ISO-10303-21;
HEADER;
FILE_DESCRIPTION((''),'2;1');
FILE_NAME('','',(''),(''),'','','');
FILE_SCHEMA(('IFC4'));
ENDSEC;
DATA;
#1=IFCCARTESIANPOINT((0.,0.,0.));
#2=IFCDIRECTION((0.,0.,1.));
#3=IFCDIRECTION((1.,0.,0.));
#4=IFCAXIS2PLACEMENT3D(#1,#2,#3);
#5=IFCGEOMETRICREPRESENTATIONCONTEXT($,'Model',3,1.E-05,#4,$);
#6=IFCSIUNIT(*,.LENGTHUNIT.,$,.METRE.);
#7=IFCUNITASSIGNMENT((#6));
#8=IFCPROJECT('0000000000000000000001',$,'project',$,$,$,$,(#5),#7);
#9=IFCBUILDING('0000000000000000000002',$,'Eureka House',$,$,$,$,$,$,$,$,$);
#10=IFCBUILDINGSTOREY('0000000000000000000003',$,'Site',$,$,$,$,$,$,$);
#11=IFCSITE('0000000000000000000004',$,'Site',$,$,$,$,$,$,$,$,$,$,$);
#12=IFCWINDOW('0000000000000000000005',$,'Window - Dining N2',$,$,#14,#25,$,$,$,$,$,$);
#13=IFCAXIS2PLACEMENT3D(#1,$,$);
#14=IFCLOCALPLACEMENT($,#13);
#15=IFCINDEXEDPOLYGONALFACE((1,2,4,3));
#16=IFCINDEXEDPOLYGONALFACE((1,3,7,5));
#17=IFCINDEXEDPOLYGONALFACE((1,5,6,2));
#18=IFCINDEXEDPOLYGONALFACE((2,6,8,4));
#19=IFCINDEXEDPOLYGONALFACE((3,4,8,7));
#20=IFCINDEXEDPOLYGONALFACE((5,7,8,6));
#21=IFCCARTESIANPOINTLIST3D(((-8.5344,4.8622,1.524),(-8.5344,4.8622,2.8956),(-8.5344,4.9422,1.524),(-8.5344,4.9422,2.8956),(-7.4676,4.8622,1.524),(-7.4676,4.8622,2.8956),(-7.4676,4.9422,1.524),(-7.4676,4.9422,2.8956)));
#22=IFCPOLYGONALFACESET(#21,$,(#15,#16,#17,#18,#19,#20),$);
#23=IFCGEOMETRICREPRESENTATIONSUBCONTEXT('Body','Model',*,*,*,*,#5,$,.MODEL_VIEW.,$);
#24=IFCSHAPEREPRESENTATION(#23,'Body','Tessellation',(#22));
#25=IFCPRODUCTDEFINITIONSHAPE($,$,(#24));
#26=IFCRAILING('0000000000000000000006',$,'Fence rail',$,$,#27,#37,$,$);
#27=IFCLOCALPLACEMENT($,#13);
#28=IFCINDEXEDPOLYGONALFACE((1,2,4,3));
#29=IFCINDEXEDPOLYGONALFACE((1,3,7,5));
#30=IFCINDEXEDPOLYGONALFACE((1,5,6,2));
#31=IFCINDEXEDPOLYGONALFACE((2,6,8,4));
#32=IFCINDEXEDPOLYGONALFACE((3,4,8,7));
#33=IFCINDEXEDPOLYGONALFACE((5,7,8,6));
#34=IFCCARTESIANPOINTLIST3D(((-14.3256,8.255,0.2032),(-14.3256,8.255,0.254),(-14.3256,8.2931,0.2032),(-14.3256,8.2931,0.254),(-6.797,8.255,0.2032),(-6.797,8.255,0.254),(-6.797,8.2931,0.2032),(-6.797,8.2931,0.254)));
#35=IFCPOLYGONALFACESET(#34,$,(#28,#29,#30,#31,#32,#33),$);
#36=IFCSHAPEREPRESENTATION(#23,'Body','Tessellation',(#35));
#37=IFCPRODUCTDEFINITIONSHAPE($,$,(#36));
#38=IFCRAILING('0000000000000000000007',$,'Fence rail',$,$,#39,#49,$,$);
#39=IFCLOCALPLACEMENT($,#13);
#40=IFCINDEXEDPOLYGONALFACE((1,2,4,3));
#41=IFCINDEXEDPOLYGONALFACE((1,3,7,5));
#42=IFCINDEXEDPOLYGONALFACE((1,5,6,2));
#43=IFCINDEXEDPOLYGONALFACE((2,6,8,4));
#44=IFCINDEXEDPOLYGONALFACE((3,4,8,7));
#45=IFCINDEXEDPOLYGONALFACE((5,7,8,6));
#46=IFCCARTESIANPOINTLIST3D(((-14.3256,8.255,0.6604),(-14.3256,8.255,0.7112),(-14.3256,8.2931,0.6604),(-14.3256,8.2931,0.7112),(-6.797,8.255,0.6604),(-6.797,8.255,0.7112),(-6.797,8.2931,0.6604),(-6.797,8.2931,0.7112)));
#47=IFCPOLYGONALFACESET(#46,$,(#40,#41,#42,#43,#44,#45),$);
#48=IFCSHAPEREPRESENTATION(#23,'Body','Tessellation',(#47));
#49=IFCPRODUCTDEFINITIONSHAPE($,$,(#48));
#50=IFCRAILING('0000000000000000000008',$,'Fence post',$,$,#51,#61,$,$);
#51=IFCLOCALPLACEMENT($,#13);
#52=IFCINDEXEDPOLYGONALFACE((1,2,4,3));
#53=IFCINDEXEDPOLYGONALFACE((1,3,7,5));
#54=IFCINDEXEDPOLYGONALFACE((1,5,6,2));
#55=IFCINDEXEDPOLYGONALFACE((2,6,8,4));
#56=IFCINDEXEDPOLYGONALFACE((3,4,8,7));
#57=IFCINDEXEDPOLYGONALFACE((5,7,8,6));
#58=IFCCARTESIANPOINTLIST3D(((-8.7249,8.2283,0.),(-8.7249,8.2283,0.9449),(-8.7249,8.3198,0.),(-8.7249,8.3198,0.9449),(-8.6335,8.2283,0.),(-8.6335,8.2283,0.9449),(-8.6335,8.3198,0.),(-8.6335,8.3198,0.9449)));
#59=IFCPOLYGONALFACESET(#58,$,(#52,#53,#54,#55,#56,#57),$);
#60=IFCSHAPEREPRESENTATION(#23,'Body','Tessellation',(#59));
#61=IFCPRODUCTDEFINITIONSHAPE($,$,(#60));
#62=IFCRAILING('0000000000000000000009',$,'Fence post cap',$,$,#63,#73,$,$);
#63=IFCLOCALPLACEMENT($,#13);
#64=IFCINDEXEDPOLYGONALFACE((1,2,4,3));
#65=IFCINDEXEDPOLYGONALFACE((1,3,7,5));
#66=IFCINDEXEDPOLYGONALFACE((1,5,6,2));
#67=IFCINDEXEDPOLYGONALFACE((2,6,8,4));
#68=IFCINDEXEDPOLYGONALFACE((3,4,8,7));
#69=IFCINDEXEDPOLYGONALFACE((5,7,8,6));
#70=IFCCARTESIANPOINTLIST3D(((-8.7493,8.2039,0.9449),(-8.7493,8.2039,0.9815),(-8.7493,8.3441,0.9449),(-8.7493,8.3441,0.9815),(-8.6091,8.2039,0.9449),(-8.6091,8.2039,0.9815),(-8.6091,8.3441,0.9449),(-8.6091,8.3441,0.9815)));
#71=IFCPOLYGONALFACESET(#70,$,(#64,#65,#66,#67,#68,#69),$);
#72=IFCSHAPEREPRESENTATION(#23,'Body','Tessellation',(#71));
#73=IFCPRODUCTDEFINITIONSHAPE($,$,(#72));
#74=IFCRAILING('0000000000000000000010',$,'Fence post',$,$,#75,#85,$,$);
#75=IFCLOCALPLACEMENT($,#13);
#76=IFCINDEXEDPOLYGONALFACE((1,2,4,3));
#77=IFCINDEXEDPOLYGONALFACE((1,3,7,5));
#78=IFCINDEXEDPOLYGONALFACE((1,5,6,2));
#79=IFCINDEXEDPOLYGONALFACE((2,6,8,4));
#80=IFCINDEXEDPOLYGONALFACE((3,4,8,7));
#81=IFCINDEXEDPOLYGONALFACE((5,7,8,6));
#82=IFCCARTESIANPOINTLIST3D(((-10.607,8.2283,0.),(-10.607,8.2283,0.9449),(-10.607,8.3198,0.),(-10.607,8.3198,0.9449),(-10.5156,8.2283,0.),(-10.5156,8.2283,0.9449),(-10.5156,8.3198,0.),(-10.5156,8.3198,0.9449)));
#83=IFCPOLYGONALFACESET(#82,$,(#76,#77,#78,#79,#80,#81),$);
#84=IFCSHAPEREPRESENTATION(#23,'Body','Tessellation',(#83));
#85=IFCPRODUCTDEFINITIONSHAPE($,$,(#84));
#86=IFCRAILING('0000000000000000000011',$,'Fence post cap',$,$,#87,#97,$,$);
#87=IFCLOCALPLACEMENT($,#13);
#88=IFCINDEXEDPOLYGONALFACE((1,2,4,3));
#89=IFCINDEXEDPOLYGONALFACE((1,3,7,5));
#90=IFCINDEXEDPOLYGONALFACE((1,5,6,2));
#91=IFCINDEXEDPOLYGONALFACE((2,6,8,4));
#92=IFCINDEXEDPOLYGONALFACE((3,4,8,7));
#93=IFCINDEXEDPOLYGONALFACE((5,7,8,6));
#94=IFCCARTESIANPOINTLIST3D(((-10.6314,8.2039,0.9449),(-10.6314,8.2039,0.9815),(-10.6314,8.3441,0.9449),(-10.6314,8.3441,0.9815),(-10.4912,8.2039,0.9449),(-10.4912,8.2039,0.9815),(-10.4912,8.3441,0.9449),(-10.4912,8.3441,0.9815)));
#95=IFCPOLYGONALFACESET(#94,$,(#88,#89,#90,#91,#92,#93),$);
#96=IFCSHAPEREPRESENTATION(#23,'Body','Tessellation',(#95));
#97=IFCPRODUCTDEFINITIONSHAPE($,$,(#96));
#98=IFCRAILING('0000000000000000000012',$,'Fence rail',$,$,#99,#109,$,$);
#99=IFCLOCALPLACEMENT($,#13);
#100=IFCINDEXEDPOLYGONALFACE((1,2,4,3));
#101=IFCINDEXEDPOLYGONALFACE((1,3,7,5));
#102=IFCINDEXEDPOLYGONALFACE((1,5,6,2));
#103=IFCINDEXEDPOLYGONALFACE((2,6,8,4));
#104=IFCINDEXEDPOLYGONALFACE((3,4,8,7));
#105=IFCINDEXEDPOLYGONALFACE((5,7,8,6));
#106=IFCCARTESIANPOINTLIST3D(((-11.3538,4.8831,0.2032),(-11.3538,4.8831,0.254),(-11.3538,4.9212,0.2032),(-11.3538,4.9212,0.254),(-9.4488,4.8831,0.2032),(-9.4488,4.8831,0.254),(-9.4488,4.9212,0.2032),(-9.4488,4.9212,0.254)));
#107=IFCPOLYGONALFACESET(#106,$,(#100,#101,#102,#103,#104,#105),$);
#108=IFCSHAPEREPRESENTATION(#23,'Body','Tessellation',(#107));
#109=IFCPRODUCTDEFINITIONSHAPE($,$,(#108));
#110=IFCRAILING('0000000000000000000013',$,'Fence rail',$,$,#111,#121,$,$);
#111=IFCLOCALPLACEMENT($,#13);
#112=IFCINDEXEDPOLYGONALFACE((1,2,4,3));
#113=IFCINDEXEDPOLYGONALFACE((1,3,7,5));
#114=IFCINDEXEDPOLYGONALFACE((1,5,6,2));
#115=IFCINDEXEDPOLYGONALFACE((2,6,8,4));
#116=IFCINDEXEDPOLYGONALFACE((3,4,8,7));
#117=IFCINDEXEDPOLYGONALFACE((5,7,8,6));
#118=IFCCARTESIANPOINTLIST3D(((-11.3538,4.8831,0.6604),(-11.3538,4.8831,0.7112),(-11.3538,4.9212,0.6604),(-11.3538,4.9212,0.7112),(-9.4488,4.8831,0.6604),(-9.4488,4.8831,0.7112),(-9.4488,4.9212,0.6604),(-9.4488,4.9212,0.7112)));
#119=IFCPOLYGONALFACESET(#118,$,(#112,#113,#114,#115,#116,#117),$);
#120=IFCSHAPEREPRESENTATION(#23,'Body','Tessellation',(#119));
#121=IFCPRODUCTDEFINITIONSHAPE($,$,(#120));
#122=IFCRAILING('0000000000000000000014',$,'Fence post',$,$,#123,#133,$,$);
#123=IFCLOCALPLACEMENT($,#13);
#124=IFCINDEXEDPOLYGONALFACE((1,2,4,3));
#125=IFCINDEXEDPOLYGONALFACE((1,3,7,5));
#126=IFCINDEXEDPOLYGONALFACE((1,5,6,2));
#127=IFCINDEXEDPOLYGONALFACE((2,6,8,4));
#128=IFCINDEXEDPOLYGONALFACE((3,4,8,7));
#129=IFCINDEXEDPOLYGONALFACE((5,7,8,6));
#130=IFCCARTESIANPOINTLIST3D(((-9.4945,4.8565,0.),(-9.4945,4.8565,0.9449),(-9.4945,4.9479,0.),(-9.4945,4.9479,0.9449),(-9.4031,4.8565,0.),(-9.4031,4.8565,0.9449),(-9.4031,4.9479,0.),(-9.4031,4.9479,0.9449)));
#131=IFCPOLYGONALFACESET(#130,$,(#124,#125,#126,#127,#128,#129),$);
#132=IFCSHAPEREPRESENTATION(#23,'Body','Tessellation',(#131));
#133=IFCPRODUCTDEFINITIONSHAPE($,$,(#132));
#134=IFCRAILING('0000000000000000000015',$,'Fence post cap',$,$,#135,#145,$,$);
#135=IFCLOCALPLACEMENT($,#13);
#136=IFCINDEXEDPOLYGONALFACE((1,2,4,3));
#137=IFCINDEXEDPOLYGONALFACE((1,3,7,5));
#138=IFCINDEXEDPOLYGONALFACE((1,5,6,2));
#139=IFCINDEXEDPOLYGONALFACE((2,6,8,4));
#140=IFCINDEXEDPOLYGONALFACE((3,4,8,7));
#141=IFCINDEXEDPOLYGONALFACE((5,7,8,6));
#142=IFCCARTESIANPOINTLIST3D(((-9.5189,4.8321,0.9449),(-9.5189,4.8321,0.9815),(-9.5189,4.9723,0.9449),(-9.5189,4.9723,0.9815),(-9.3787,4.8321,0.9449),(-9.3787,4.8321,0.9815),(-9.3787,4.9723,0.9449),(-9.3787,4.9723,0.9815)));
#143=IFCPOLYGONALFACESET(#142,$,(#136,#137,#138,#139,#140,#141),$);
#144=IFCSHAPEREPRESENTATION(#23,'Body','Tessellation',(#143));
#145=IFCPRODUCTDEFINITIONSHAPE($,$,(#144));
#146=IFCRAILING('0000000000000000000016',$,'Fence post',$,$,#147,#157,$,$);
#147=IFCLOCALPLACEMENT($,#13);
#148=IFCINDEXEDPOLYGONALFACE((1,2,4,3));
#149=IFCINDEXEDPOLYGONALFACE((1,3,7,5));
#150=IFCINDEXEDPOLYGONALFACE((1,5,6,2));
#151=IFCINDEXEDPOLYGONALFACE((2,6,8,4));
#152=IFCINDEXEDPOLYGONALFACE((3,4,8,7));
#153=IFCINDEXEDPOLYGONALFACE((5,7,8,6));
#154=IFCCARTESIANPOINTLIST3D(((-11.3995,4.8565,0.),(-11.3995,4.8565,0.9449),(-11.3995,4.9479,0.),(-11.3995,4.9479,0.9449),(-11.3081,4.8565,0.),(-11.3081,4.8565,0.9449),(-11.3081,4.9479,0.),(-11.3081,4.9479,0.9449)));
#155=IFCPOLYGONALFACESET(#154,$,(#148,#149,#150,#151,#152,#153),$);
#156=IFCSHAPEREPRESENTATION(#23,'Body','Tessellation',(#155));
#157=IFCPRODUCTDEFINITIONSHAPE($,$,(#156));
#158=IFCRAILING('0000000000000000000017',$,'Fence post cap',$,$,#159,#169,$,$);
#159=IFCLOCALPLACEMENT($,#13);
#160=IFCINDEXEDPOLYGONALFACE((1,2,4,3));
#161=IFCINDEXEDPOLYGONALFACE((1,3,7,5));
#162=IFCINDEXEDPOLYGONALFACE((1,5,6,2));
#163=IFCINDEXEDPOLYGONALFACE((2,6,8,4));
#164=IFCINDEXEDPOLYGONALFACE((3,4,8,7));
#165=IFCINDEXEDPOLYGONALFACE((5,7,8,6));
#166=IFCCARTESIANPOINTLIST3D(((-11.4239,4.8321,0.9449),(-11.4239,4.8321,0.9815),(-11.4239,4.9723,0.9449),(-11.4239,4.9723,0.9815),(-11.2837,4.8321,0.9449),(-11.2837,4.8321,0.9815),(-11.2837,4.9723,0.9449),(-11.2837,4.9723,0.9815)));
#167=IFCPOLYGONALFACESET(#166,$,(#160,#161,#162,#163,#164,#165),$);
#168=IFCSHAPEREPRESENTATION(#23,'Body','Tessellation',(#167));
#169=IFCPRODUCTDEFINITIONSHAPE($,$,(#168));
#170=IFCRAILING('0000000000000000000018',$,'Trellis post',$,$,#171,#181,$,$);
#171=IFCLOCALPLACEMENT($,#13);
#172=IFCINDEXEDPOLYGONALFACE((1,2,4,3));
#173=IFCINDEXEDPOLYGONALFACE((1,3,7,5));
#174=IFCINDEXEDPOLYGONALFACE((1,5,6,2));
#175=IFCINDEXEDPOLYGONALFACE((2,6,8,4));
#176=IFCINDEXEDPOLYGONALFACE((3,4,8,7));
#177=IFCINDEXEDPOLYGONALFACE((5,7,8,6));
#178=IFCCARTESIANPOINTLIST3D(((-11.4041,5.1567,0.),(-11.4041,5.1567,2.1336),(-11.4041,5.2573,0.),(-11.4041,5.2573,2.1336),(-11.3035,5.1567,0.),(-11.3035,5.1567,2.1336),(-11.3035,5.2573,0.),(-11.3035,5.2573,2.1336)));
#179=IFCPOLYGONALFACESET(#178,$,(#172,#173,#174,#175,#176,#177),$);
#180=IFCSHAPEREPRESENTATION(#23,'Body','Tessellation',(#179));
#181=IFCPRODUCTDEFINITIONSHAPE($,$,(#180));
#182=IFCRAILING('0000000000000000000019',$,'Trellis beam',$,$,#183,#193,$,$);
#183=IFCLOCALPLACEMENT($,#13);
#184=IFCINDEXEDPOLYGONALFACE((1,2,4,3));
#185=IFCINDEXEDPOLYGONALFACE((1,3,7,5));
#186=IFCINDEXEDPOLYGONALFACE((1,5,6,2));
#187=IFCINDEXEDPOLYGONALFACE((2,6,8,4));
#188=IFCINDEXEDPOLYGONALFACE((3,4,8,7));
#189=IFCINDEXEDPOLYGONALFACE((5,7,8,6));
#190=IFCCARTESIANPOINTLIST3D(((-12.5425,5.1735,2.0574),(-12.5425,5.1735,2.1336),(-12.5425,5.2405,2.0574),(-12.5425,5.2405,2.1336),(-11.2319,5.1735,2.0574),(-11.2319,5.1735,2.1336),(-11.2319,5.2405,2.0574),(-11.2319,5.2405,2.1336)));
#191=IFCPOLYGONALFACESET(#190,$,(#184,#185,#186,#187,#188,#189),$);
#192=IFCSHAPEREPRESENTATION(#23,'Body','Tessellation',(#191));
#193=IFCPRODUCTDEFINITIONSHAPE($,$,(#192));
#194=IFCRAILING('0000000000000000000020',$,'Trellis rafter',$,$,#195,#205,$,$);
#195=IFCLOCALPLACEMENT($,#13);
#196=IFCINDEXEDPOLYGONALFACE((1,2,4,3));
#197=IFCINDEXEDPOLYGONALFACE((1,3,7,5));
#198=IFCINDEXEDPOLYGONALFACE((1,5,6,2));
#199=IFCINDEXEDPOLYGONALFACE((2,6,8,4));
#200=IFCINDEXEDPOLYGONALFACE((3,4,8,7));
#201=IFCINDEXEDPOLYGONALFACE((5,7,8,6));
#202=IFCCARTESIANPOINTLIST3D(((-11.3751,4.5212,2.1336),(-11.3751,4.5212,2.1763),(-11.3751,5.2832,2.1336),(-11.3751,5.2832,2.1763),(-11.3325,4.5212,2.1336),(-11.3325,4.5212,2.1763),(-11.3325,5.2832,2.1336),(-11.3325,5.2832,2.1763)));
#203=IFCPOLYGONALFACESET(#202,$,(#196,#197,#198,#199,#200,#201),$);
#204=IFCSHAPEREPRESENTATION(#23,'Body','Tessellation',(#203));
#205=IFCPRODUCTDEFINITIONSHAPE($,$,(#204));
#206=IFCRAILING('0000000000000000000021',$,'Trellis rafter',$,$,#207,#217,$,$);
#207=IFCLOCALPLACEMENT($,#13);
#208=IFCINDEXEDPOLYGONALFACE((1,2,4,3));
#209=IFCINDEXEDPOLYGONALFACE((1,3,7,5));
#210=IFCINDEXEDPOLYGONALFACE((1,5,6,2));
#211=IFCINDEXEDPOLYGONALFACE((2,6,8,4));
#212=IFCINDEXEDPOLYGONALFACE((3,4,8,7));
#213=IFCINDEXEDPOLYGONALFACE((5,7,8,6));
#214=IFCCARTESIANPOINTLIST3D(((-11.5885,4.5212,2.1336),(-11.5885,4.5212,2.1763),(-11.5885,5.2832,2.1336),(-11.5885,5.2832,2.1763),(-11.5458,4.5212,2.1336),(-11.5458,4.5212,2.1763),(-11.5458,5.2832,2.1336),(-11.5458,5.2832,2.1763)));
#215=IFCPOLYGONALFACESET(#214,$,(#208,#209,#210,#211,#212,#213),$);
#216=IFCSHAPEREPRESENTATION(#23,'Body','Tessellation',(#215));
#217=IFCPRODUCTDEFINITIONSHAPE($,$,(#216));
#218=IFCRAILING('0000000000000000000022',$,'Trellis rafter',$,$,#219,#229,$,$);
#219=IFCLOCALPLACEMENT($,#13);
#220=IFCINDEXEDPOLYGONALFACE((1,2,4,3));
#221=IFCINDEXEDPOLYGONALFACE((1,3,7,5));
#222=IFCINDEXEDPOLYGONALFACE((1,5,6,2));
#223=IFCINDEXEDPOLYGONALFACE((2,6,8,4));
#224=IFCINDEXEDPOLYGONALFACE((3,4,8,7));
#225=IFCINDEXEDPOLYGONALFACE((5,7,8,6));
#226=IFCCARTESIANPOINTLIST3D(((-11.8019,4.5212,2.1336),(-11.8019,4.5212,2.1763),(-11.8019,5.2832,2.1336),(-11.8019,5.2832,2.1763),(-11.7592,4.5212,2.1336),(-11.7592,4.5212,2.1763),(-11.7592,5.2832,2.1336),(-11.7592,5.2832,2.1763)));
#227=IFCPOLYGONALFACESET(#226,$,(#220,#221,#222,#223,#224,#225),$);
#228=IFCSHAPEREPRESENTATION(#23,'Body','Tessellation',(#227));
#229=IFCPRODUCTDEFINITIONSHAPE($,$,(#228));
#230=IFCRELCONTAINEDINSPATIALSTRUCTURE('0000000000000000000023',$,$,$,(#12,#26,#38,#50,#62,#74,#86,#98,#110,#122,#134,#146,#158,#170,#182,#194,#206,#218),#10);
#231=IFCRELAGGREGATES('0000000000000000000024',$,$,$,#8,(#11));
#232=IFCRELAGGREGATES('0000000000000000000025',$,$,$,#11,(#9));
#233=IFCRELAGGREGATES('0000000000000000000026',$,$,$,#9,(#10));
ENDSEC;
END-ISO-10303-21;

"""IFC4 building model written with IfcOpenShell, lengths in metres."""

from ifc_helpers import new_model, si_unit, frame, origin, origin_with_axes, origin_2d, place, context, subcontext, project, spatial, rectangle, extrude, element, save


model = new_model("IFC4")

# Units and contexts
model_context = context("Model", 3, precision=1e-05, world=origin_with_axes())
body_context = subcontext(model_context, "Body", "Model", "MODEL_VIEW")
ifc_project = project(units=[si_unit("LENGTHUNIT", "METRE")], contexts=[model_context])

# Site, building, storey
site = spatial("IfcSite", under=ifc_project, Name="Site")
building = spatial("IfcBuilding", under=site, Name="Eureka House")
storey = spatial("IfcBuildingStorey", under=building, Name="Site")

# Window
window_placement = place(None, frame((-8.001, 4.9022, 1.524), z_axis=(0.0, 0.0, 1.0), x_axis=(1.0, 0.0, 0.0)))
element("IfcWindow", 1, at=window_placement, inside=storey, Name="Window - Dining N2", context=body_context, shape_type="SweptSolid", body=[
    extrude(rectangle(XDim=1.0668, YDim=0.08, at=origin_2d()), origin(), (0.0, 0.0, 1.0), 1.3716),
])

# Railings
for number, where, z_axis, x_axis, name in (
    (2, (-10.5613, 8.274, 0.2032), (0.0, 0.0, 1.0), (1.0, 0.0, 0.0), "Fence rail"),
    (3, (-10.5613, 8.274, 0.6604), (0.0, 0.0, 1.0), (1.0, 0.0, 0.0), "Fence rail"),
):
    element("IfcRailing", number, at=place(None, frame(where, z_axis=z_axis, x_axis=x_axis)), inside=storey, Name=name, context=body_context, shape_type="SweptSolid", body=[
        extrude(rectangle(XDim=7.5286, YDim=0.0381, at=origin_2d()), origin(), (0.0, 0.0, 1.0), 0.0508),
    ])
railing_1_placement = place(None, frame((-8.6792, 8.274, 0.0), z_axis=(0.0, 0.0, 1.0), x_axis=(1.0, 0.0, 0.0)))
element("IfcRailing", 4, at=railing_1_placement, inside=storey, Name="Fence post", context=body_context, shape_type="SweptSolid", body=[
    extrude(rectangle(XDim=0.0914, YDim=0.0914, at=origin_2d()), origin(), (0.0, 0.0, 1.0), 0.9449),
])
railing_2_placement = place(None, frame((-8.6792, 8.274, 0.9449), z_axis=(0.0, 0.0, 1.0), x_axis=(1.0, 0.0, 0.0)))
element("IfcRailing", 5, at=railing_2_placement, inside=storey, Name="Fence post cap", context=body_context, shape_type="SweptSolid", body=[
    extrude(rectangle(XDim=0.1402, YDim=0.1402, at=origin_2d()), origin(), (0.0, 0.0, 1.0), 0.0366),
])
railing_3_placement = place(None, frame((-10.5613, 8.274, 0.0), z_axis=(0.0, 0.0, 1.0), x_axis=(1.0, 0.0, 0.0)))
element("IfcRailing", 6, at=railing_3_placement, inside=storey, Name="Fence post", context=body_context, shape_type="SweptSolid", body=[
    extrude(rectangle(XDim=0.0914, YDim=0.0914, at=origin_2d()), origin(), (0.0, 0.0, 1.0), 0.9449),
])
railing_4_placement = place(None, frame((-10.5613, 8.274, 0.9449), z_axis=(0.0, 0.0, 1.0), x_axis=(1.0, 0.0, 0.0)))
element("IfcRailing", 7, at=railing_4_placement, inside=storey, Name="Fence post cap", context=body_context, shape_type="SweptSolid", body=[
    extrude(rectangle(XDim=0.1402, YDim=0.1402, at=origin_2d()), origin(), (0.0, 0.0, 1.0), 0.0366),
])
for number, where, z_axis, x_axis, name in (
    (8, (-10.4013, 4.9022, 0.2032), (0.0, 0.0, 1.0), (1.0, 0.0, 0.0), "Fence rail"),
    (9, (-10.4013, 4.9022, 0.6604), (0.0, 0.0, 1.0), (1.0, 0.0, 0.0), "Fence rail"),
):
    element("IfcRailing", number, at=place(None, frame(where, z_axis=z_axis, x_axis=x_axis)), inside=storey, Name=name, context=body_context, shape_type="SweptSolid", body=[
        extrude(rectangle(XDim=1.905, YDim=0.0381, at=origin_2d()), origin(), (0.0, 0.0, 1.0), 0.0508),
    ])
railing_5_placement = place(None, frame((-9.4488, 4.9022, 0.0), z_axis=(0.0, 0.0, 1.0), x_axis=(1.0, 0.0, 0.0)))
element("IfcRailing", 10, at=railing_5_placement, inside=storey, Name="Fence post", context=body_context, shape_type="SweptSolid", body=[
    extrude(rectangle(XDim=0.0914, YDim=0.0914, at=origin_2d()), origin(), (0.0, 0.0, 1.0), 0.9449),
])
railing_6_placement = place(None, frame((-9.4488, 4.9022, 0.9449), z_axis=(0.0, 0.0, 1.0), x_axis=(1.0, 0.0, 0.0)))
element("IfcRailing", 11, at=railing_6_placement, inside=storey, Name="Fence post cap", context=body_context, shape_type="SweptSolid", body=[
    extrude(rectangle(XDim=0.1402, YDim=0.1402, at=origin_2d()), origin(), (0.0, 0.0, 1.0), 0.0366),
])
railing_7_placement = place(None, frame((-11.3538, 4.9022, 0.0), z_axis=(0.0, 0.0, 1.0), x_axis=(1.0, 0.0, 0.0)))
element("IfcRailing", 12, at=railing_7_placement, inside=storey, Name="Fence post", context=body_context, shape_type="SweptSolid", body=[
    extrude(rectangle(XDim=0.0914, YDim=0.0914, at=origin_2d()), origin(), (0.0, 0.0, 1.0), 0.9449),
])
railing_8_placement = place(None, frame((-11.3538, 4.9022, 0.9449), z_axis=(0.0, 0.0, 1.0), x_axis=(1.0, 0.0, 0.0)))
element("IfcRailing", 13, at=railing_8_placement, inside=storey, Name="Fence post cap", context=body_context, shape_type="SweptSolid", body=[
    extrude(rectangle(XDim=0.1402, YDim=0.1402, at=origin_2d()), origin(), (0.0, 0.0, 1.0), 0.0366),
])
railing_9_placement = place(None, frame((-11.3538, 5.207, 0.0), z_axis=(0.0, 0.0, 1.0), x_axis=(1.0, 0.0, 0.0)))
element("IfcRailing", 14, at=railing_9_placement, inside=storey, Name="Trellis post", context=body_context, shape_type="SweptSolid", body=[
    extrude(rectangle(XDim=0.1006, YDim=0.1006, at=origin_2d()), origin(), (0.0, 0.0, 1.0), 2.1336),
])
railing_10_placement = place(None, frame((-11.8872, 5.207, 2.0574), z_axis=(0.0, 0.0, 1.0), x_axis=(1.0, 0.0, 0.0)))
element("IfcRailing", 15, at=railing_10_placement, inside=storey, Name="Trellis beam", context=body_context, shape_type="SweptSolid", body=[
    extrude(rectangle(XDim=1.3106, YDim=0.0671, at=origin_2d()), origin(), (0.0, 0.0, 1.0), 0.0762),
])
for number, where, z_axis, x_axis, name in (
    (16, (-11.3538, 4.9022, 2.1336), (0.0, 0.0, 1.0), (1.0, 0.0, 0.0), "Trellis rafter"),
    (17, (-11.5672, 4.9022, 2.1336), (0.0, 0.0, 1.0), (1.0, 0.0, 0.0), "Trellis rafter"),
    (18, (-11.7805, 4.9022, 2.1336), (0.0, 0.0, 1.0), (1.0, 0.0, 0.0), "Trellis rafter"),
):
    element("IfcRailing", number, at=place(None, frame(where, z_axis=z_axis, x_axis=x_axis)), inside=storey, Name=name, context=body_context, shape_type="SweptSolid", body=[
        extrude(rectangle(XDim=0.0427, YDim=0.762, at=origin_2d()), origin(), (0.0, 0.0, 1.0), 0.0427),
    ])

save(model, "model.ifc")
